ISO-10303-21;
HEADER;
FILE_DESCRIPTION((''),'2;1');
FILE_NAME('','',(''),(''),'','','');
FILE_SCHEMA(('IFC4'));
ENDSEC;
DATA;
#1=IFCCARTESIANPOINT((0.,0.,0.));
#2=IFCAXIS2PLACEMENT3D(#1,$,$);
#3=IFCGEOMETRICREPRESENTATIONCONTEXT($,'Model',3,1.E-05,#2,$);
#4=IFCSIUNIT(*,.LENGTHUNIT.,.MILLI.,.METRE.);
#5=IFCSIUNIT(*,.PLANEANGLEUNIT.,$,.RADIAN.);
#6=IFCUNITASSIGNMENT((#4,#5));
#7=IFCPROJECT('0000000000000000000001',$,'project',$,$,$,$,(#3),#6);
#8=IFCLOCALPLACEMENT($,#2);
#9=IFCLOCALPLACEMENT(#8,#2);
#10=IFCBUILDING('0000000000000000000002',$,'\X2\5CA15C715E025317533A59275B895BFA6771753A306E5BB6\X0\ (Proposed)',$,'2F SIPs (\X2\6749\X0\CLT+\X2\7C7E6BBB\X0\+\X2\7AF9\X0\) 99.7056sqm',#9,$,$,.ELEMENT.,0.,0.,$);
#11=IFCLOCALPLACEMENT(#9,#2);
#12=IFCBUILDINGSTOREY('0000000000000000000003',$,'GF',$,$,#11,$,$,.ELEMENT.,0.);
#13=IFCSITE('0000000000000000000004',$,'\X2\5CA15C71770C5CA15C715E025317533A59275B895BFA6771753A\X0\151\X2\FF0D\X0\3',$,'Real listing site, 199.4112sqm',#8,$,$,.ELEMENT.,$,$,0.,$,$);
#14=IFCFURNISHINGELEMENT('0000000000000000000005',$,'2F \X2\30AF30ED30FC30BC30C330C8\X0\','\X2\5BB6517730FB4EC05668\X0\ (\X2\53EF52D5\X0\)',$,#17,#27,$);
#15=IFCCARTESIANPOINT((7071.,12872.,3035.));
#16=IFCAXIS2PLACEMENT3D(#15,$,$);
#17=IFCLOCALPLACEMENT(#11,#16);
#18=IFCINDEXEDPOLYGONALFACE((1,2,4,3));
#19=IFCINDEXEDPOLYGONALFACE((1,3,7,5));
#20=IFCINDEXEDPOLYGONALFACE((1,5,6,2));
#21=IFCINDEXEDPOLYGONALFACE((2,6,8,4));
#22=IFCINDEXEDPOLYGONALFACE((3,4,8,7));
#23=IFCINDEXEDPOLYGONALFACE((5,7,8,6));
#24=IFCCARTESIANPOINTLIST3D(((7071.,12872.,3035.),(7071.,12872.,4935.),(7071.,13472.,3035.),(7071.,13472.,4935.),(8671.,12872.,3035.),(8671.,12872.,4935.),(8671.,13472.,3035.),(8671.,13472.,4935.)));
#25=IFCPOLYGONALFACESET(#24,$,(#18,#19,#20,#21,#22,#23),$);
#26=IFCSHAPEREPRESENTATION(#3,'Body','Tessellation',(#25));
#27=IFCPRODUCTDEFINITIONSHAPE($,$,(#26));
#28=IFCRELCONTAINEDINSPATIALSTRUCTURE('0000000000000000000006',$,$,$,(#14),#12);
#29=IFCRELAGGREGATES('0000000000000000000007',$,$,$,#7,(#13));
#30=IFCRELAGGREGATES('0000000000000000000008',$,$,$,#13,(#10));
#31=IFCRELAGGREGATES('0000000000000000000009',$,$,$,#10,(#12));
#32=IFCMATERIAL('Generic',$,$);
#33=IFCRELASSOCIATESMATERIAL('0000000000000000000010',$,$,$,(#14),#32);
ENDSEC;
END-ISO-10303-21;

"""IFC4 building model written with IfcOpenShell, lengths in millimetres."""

from ifc_helpers import new_model, si_unit, frame, frame_2d, origin, place, context, project, spatial, rectangle, extrude, material, element, save


model = new_model("IFC4")

# Units and contexts
model_context = context("Model", 3, precision=1e-05, world=origin())
ifc_project = project(units=[si_unit("LENGTHUNIT", "METRE", prefix="MILLI"), si_unit("PLANEANGLEUNIT", "RADIAN")], contexts=[model_context])

# Site, building, storey
site_placement = place(None, origin())
site = spatial("IfcSite", under=ifc_project, at=site_placement, Name="岡山県岡山市北区大安寺東町151－3", ObjectType="Real listing site, 199.4112sqm", CompositionType="ELEMENT", RefElevation=0.0)
building_placement = place(site_placement, origin())
building = spatial("IfcBuilding", under=site, at=building_placement, Name="岡山市北区大安寺東町の家 (Proposed)", ObjectType="2F SIPs (杉CLT+籾殻+竹) 99.7056sqm", CompositionType="ELEMENT", ElevationOfRefHeight=0.0, ElevationOfTerrain=0.0)
storey_placement = place(building_placement, origin())
storey = spatial("IfcBuildingStorey", under=building, at=storey_placement, Name="GF", CompositionType="ELEMENT", Elevation=0.0)

# Shared definitions
ifc_material_1 = material(Name="Generic")

# Furnishing element
furnishing_1_placement = place(storey_placement, frame((7071.0, 12872.0, 3035.0)))
element("IfcFurnishingElement", 1, at=furnishing_1_placement, inside=storey, material=ifc_material_1, Name="2F クローゼット", Description="家具・什器 (可動)", context=model_context, shape_type="SweptSolid", body=[
    extrude(rectangle(XDim=1600.0, YDim=600.0, at=frame_2d((800.0, 300.0))), frame((7071.0, 12872.0, 3035.0)), (0.0, 0.0, 1.0), 1900.0),
])

save(model, "model.ifc")
